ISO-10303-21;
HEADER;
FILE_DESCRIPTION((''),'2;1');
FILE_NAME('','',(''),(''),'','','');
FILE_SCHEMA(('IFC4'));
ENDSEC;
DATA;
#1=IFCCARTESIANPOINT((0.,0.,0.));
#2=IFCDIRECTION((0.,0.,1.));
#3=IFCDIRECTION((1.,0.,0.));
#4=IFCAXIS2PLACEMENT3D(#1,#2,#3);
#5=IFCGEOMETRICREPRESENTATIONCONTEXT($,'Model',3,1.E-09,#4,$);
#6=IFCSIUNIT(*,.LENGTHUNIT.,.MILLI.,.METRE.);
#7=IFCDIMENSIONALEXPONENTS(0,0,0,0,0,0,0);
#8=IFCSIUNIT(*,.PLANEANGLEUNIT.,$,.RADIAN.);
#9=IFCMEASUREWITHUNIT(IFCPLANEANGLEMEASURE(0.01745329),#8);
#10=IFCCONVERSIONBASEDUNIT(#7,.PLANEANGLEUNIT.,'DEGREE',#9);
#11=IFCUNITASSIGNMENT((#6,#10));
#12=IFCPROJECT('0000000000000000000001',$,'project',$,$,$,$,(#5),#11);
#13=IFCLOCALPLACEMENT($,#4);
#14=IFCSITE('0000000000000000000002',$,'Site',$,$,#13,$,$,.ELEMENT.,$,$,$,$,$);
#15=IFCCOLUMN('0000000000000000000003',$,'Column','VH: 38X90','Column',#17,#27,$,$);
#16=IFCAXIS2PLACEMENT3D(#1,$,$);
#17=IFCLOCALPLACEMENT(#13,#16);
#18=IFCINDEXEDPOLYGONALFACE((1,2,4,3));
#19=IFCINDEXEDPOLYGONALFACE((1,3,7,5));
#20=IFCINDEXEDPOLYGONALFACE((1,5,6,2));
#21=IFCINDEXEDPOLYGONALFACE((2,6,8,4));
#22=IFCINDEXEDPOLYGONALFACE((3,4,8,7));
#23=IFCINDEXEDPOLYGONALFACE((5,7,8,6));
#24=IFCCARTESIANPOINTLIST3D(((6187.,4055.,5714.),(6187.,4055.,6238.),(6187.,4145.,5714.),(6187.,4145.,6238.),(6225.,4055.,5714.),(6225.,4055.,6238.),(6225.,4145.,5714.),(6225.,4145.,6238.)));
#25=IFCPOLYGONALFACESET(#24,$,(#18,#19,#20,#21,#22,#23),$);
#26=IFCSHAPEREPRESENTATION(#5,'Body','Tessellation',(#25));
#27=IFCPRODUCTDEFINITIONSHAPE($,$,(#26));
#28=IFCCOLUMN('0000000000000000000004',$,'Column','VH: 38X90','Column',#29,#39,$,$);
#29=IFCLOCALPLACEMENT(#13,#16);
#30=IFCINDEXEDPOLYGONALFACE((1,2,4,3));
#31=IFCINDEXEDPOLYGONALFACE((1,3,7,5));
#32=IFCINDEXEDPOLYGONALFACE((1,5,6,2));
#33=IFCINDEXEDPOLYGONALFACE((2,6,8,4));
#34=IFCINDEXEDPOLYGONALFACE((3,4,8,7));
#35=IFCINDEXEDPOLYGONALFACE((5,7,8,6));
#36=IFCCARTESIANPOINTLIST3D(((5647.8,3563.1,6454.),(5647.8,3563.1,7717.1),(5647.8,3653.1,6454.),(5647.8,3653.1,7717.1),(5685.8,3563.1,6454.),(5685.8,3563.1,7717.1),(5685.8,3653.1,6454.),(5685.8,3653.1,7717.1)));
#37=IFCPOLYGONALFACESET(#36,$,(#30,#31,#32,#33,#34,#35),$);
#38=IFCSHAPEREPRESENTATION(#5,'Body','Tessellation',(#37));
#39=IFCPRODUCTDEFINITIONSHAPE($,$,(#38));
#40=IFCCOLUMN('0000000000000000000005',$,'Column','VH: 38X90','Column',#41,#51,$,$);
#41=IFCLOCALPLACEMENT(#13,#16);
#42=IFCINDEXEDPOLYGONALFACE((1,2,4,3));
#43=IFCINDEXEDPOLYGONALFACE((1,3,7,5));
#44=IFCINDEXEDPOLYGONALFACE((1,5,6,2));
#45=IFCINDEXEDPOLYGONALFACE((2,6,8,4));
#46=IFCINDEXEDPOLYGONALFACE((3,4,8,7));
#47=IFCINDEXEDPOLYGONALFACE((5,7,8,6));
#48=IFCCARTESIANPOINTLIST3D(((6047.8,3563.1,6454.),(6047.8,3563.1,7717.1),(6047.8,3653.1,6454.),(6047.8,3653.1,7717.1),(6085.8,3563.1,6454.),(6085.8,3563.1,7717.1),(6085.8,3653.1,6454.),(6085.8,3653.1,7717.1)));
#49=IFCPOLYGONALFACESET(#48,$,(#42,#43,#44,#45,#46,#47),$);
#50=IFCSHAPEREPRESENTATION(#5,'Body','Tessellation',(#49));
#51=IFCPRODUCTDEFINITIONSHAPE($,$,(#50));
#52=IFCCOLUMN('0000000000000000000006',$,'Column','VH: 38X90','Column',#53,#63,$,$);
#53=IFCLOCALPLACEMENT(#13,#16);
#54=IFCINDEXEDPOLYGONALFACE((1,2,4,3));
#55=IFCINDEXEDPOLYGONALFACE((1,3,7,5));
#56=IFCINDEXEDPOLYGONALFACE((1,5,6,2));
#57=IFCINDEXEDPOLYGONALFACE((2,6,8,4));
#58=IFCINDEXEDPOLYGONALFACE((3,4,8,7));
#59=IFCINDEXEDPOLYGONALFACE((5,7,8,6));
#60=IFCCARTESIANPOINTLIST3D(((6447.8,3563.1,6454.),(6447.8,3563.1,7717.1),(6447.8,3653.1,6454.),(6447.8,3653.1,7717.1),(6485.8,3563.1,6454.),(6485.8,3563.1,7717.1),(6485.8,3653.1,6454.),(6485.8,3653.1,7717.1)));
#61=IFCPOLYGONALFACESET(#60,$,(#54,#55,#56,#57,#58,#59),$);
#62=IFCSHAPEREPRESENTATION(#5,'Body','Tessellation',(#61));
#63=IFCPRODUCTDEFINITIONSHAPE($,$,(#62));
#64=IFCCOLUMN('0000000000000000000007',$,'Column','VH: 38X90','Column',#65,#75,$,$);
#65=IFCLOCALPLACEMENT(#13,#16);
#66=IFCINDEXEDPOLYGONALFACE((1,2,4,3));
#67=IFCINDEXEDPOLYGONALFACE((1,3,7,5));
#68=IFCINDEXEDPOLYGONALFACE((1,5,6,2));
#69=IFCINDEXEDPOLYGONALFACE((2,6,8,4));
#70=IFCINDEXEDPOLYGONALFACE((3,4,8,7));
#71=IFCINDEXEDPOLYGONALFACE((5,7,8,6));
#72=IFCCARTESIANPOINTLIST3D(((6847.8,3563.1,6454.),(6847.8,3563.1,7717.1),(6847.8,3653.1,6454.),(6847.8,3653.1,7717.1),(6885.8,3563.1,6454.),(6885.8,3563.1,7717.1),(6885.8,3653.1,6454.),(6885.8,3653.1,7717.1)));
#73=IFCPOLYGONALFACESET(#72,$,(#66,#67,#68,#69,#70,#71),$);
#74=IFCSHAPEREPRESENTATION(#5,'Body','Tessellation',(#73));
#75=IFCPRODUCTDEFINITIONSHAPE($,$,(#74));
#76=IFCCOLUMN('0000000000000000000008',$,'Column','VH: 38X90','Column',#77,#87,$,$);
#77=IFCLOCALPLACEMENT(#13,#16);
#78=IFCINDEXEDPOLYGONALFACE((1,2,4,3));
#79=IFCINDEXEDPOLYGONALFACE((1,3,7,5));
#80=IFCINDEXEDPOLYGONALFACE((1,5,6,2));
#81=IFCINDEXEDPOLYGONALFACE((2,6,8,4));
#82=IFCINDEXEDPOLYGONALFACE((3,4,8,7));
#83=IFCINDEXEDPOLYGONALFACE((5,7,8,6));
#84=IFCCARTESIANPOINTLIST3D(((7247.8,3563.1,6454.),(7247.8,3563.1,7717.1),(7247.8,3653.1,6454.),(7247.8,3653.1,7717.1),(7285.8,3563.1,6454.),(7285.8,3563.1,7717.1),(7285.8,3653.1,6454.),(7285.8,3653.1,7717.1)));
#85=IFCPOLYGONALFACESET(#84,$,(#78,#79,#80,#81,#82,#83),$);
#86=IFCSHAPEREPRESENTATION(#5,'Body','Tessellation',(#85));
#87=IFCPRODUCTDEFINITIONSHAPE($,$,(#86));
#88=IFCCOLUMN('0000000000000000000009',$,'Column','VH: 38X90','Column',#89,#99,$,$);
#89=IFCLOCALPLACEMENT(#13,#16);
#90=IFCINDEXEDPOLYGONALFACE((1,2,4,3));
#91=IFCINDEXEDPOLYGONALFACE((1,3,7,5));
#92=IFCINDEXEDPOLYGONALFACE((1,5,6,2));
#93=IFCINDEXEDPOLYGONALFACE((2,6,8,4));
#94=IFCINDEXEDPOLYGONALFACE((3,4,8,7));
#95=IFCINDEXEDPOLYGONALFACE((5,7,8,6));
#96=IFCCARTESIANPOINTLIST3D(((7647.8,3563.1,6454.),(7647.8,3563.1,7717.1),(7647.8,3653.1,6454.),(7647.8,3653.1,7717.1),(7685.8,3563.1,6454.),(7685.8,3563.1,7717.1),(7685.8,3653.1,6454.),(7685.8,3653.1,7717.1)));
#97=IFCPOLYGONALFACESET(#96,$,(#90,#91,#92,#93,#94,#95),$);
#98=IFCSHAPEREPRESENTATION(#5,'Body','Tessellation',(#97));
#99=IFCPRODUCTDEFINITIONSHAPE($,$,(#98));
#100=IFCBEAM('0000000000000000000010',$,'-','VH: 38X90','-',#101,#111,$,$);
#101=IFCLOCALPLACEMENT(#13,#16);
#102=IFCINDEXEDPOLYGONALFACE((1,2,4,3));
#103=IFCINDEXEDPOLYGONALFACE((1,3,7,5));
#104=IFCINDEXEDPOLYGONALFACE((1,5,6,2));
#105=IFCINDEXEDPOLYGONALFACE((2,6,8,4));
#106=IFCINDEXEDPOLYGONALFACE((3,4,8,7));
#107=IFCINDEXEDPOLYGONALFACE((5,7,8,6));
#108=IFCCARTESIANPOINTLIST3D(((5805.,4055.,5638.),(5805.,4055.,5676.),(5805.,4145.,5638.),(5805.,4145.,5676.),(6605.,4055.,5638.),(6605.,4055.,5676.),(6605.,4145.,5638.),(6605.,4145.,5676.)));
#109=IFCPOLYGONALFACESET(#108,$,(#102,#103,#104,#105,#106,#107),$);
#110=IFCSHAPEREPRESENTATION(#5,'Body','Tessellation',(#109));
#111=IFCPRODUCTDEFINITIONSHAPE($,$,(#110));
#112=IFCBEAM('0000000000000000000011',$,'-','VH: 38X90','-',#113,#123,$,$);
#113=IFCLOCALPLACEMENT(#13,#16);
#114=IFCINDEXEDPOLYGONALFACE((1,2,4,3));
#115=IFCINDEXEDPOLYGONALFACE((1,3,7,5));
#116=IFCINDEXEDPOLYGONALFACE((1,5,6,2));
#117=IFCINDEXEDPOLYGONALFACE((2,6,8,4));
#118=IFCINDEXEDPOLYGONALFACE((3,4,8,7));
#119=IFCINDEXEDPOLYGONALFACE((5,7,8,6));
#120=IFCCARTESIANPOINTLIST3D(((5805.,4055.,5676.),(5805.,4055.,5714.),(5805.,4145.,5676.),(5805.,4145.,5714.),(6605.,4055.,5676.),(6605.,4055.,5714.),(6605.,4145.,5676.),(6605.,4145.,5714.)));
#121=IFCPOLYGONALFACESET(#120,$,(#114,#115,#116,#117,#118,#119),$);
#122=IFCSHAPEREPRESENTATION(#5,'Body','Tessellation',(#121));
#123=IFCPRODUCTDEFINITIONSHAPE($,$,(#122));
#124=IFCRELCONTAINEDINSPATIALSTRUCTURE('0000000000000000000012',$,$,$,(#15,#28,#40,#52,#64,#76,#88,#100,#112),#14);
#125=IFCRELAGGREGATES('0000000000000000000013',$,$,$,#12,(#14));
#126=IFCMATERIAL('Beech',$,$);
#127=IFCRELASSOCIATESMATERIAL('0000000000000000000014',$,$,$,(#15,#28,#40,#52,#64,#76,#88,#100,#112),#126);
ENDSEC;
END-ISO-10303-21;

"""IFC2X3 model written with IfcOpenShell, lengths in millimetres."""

from ifc_helpers import new_model, entity, si_unit, converted_unit, frame, origin, origin_with_axes, origin_2d, place, context, project, spatial, rectangle, extrude, clip, halfspace, material, element, save


model = new_model("IFC2X3")

# Units and contexts
model_context = context("Model", 3, precision=1e-09, world=origin_with_axes())
ifc_project = project(units=[si_unit("LENGTHUNIT", "METRE", prefix="MILLI"), converted_unit("PLANEANGLEUNIT", "DEGREE", entity("IfcPlaneAngleMeasure", 0.01745329), si_unit("PLANEANGLEUNIT", "RADIAN"), dimensions=[0, 0, 0, 0, 0, 0, 0])], contexts=[model_context])

# Site
site_placement = place(None, origin_with_axes())
site = spatial("IfcSite", under=ifc_project, at=site_placement, Name="Site", CompositionType="ELEMENT")

# Columns
ifc_material = material(Name="Beech")
column_1_placement = place(None, frame((6206.0, 4100.0, 5714.0), z_axis=(0.0, 0.0, -1.0), x_axis=(-1.0, 0.0, 0.0)))
element("IfcColumn", 1, at=column_1_placement, inside=site, material=ifc_material, Name="Column", Description="VH: 38X90", ObjectType="Column", context=model_context, shape_type="SweptSolid", body=[
    extrude(rectangle(XDim=38.0, YDim=90.0, at=origin_2d()), origin(), (0.0, 0.0, -1.0), 524.0),
])
column_2_placement = place(None, frame((5666.8, 3608.1, 6454.0), z_axis=(0.0, 0.0, -1.0), x_axis=(-1.0, 0.0, 0.0)))
element("IfcColumn", 2, at=column_2_placement, inside=site, material=ifc_material, Name="Column", Description="VH: 38X90", ObjectType="Column", context=model_context, shape_type="Clipping", body=[
    clip(extrude(rectangle(XDim=38.0, YDim=90.0, at=origin_2d()), origin(), (0.0, 0.0, -1.0), 1493.8), halfspace(frame((5666.8, -3608.1, -1263.1), z_axis=(0.0, 0.0, 1.0), x_axis=(1.0, 0.0, 0.0)), True)),
])
column_3_placement = place(None, frame((6066.8, 3608.1, 6454.0), z_axis=(0.0, 0.0, -1.0), x_axis=(-1.0, 0.0, 0.0)))
element("IfcColumn", 3, at=column_3_placement, inside=site, material=ifc_material, Name="Column", Description="VH: 38X90", ObjectType="Column", context=model_context, shape_type="Clipping", body=[
    clip(extrude(rectangle(XDim=38.0, YDim=90.0, at=origin_2d()), origin(), (0.0, 0.0, -1.0), 1493.8), halfspace(frame((6066.8, -3608.1, -1263.1), z_axis=(0.0, 0.0, 1.0), x_axis=(1.0, 0.0, 0.0)), True)),
])
column_4_placement = place(None, frame((6466.8, 3608.1, 6454.0), z_axis=(0.0, 0.0, -1.0), x_axis=(-1.0, 0.0, 0.0)))
element("IfcColumn", 4, at=column_4_placement, inside=site, material=ifc_material, Name="Column", Description="VH: 38X90", ObjectType="Column", context=model_context, shape_type="Clipping", body=[
    clip(extrude(rectangle(XDim=38.0, YDim=90.0, at=origin_2d()), origin(), (0.0, 0.0, -1.0), 1493.8), halfspace(frame((6466.8, -3608.1, -1263.1), z_axis=(0.0, 0.0, 1.0), x_axis=(1.0, 0.0, 0.0)), True)),
])
column_5_placement = place(None, frame((6866.8, 3608.1, 6454.0), z_axis=(0.0, 0.0, -1.0), x_axis=(-1.0, 0.0, 0.0)))
element("IfcColumn", 5, at=column_5_placement, inside=site, material=ifc_material, Name="Column", Description="VH: 38X90", ObjectType="Column", context=model_context, shape_type="Clipping", body=[
    clip(extrude(rectangle(XDim=38.0, YDim=90.0, at=origin_2d()), origin(), (0.0, 0.0, -1.0), 1493.8), halfspace(frame((6866.8, -3608.1, -1263.1), z_axis=(0.0, 0.0, 1.0), x_axis=(1.0, 0.0, 0.0)), True)),
])
column_6_placement = place(None, frame((7266.8, 3608.1, 6454.0), z_axis=(0.0, 0.0, -1.0), x_axis=(-1.0, 0.0, 0.0)))
element("IfcColumn", 6, at=column_6_placement, inside=site, material=ifc_material, Name="Column", Description="VH: 38X90", ObjectType="Column", context=model_context, shape_type="Clipping", body=[
    clip(extrude(rectangle(XDim=38.0, YDim=90.0, at=origin_2d()), origin(), (0.0, 0.0, -1.0), 1493.8), halfspace(frame((7266.8, -3608.1, -1263.1), z_axis=(0.0, 0.0, 1.0), x_axis=(1.0, 0.0, 0.0)), True)),
])
column_7_placement = place(None, frame((7666.8, 3608.1, 6454.0), z_axis=(0.0, 0.0, -1.0), x_axis=(-1.0, 0.0, 0.0)))
element("IfcColumn", 7, at=column_7_placement, inside=site, material=ifc_material, Name="Column", Description="VH: 38X90", ObjectType="Column", context=model_context, shape_type="Clipping", body=[
    clip(extrude(rectangle(XDim=38.0, YDim=90.0, at=origin_2d()), origin(), (0.0, 0.0, -1.0), 1493.8), halfspace(frame((7666.8, -3608.1, -1263.1), z_axis=(0.0, 0.0, 1.0), x_axis=(1.0, 0.0, 0.0)), True)),
])

# Beams
for number, where, z_axis, x_axis, name in (
    (8, (5805.0, 4100.0, 5657.0), (-1.0, 0.0, 0.0), (0.0, 0.0, -1.0), "-"),
    (9, (5805.0, 4100.0, 5695.0), (-1.0, 0.0, 0.0), (0.0, 0.0, -1.0), "-"),
):
    element("IfcBeam", number, at=place(None, frame(where, z_axis=z_axis, x_axis=x_axis)), inside=site, material=ifc_material, Name=name, Description="VH: 38X90", ObjectType="-", context=model_context, shape_type="SweptSolid", body=[
        extrude(rectangle(XDim=38.0, YDim=90.0, at=origin_2d()), origin(), (0.0, 0.0, -1.0), 800.0),
    ])

save(model, "model.ifc")
